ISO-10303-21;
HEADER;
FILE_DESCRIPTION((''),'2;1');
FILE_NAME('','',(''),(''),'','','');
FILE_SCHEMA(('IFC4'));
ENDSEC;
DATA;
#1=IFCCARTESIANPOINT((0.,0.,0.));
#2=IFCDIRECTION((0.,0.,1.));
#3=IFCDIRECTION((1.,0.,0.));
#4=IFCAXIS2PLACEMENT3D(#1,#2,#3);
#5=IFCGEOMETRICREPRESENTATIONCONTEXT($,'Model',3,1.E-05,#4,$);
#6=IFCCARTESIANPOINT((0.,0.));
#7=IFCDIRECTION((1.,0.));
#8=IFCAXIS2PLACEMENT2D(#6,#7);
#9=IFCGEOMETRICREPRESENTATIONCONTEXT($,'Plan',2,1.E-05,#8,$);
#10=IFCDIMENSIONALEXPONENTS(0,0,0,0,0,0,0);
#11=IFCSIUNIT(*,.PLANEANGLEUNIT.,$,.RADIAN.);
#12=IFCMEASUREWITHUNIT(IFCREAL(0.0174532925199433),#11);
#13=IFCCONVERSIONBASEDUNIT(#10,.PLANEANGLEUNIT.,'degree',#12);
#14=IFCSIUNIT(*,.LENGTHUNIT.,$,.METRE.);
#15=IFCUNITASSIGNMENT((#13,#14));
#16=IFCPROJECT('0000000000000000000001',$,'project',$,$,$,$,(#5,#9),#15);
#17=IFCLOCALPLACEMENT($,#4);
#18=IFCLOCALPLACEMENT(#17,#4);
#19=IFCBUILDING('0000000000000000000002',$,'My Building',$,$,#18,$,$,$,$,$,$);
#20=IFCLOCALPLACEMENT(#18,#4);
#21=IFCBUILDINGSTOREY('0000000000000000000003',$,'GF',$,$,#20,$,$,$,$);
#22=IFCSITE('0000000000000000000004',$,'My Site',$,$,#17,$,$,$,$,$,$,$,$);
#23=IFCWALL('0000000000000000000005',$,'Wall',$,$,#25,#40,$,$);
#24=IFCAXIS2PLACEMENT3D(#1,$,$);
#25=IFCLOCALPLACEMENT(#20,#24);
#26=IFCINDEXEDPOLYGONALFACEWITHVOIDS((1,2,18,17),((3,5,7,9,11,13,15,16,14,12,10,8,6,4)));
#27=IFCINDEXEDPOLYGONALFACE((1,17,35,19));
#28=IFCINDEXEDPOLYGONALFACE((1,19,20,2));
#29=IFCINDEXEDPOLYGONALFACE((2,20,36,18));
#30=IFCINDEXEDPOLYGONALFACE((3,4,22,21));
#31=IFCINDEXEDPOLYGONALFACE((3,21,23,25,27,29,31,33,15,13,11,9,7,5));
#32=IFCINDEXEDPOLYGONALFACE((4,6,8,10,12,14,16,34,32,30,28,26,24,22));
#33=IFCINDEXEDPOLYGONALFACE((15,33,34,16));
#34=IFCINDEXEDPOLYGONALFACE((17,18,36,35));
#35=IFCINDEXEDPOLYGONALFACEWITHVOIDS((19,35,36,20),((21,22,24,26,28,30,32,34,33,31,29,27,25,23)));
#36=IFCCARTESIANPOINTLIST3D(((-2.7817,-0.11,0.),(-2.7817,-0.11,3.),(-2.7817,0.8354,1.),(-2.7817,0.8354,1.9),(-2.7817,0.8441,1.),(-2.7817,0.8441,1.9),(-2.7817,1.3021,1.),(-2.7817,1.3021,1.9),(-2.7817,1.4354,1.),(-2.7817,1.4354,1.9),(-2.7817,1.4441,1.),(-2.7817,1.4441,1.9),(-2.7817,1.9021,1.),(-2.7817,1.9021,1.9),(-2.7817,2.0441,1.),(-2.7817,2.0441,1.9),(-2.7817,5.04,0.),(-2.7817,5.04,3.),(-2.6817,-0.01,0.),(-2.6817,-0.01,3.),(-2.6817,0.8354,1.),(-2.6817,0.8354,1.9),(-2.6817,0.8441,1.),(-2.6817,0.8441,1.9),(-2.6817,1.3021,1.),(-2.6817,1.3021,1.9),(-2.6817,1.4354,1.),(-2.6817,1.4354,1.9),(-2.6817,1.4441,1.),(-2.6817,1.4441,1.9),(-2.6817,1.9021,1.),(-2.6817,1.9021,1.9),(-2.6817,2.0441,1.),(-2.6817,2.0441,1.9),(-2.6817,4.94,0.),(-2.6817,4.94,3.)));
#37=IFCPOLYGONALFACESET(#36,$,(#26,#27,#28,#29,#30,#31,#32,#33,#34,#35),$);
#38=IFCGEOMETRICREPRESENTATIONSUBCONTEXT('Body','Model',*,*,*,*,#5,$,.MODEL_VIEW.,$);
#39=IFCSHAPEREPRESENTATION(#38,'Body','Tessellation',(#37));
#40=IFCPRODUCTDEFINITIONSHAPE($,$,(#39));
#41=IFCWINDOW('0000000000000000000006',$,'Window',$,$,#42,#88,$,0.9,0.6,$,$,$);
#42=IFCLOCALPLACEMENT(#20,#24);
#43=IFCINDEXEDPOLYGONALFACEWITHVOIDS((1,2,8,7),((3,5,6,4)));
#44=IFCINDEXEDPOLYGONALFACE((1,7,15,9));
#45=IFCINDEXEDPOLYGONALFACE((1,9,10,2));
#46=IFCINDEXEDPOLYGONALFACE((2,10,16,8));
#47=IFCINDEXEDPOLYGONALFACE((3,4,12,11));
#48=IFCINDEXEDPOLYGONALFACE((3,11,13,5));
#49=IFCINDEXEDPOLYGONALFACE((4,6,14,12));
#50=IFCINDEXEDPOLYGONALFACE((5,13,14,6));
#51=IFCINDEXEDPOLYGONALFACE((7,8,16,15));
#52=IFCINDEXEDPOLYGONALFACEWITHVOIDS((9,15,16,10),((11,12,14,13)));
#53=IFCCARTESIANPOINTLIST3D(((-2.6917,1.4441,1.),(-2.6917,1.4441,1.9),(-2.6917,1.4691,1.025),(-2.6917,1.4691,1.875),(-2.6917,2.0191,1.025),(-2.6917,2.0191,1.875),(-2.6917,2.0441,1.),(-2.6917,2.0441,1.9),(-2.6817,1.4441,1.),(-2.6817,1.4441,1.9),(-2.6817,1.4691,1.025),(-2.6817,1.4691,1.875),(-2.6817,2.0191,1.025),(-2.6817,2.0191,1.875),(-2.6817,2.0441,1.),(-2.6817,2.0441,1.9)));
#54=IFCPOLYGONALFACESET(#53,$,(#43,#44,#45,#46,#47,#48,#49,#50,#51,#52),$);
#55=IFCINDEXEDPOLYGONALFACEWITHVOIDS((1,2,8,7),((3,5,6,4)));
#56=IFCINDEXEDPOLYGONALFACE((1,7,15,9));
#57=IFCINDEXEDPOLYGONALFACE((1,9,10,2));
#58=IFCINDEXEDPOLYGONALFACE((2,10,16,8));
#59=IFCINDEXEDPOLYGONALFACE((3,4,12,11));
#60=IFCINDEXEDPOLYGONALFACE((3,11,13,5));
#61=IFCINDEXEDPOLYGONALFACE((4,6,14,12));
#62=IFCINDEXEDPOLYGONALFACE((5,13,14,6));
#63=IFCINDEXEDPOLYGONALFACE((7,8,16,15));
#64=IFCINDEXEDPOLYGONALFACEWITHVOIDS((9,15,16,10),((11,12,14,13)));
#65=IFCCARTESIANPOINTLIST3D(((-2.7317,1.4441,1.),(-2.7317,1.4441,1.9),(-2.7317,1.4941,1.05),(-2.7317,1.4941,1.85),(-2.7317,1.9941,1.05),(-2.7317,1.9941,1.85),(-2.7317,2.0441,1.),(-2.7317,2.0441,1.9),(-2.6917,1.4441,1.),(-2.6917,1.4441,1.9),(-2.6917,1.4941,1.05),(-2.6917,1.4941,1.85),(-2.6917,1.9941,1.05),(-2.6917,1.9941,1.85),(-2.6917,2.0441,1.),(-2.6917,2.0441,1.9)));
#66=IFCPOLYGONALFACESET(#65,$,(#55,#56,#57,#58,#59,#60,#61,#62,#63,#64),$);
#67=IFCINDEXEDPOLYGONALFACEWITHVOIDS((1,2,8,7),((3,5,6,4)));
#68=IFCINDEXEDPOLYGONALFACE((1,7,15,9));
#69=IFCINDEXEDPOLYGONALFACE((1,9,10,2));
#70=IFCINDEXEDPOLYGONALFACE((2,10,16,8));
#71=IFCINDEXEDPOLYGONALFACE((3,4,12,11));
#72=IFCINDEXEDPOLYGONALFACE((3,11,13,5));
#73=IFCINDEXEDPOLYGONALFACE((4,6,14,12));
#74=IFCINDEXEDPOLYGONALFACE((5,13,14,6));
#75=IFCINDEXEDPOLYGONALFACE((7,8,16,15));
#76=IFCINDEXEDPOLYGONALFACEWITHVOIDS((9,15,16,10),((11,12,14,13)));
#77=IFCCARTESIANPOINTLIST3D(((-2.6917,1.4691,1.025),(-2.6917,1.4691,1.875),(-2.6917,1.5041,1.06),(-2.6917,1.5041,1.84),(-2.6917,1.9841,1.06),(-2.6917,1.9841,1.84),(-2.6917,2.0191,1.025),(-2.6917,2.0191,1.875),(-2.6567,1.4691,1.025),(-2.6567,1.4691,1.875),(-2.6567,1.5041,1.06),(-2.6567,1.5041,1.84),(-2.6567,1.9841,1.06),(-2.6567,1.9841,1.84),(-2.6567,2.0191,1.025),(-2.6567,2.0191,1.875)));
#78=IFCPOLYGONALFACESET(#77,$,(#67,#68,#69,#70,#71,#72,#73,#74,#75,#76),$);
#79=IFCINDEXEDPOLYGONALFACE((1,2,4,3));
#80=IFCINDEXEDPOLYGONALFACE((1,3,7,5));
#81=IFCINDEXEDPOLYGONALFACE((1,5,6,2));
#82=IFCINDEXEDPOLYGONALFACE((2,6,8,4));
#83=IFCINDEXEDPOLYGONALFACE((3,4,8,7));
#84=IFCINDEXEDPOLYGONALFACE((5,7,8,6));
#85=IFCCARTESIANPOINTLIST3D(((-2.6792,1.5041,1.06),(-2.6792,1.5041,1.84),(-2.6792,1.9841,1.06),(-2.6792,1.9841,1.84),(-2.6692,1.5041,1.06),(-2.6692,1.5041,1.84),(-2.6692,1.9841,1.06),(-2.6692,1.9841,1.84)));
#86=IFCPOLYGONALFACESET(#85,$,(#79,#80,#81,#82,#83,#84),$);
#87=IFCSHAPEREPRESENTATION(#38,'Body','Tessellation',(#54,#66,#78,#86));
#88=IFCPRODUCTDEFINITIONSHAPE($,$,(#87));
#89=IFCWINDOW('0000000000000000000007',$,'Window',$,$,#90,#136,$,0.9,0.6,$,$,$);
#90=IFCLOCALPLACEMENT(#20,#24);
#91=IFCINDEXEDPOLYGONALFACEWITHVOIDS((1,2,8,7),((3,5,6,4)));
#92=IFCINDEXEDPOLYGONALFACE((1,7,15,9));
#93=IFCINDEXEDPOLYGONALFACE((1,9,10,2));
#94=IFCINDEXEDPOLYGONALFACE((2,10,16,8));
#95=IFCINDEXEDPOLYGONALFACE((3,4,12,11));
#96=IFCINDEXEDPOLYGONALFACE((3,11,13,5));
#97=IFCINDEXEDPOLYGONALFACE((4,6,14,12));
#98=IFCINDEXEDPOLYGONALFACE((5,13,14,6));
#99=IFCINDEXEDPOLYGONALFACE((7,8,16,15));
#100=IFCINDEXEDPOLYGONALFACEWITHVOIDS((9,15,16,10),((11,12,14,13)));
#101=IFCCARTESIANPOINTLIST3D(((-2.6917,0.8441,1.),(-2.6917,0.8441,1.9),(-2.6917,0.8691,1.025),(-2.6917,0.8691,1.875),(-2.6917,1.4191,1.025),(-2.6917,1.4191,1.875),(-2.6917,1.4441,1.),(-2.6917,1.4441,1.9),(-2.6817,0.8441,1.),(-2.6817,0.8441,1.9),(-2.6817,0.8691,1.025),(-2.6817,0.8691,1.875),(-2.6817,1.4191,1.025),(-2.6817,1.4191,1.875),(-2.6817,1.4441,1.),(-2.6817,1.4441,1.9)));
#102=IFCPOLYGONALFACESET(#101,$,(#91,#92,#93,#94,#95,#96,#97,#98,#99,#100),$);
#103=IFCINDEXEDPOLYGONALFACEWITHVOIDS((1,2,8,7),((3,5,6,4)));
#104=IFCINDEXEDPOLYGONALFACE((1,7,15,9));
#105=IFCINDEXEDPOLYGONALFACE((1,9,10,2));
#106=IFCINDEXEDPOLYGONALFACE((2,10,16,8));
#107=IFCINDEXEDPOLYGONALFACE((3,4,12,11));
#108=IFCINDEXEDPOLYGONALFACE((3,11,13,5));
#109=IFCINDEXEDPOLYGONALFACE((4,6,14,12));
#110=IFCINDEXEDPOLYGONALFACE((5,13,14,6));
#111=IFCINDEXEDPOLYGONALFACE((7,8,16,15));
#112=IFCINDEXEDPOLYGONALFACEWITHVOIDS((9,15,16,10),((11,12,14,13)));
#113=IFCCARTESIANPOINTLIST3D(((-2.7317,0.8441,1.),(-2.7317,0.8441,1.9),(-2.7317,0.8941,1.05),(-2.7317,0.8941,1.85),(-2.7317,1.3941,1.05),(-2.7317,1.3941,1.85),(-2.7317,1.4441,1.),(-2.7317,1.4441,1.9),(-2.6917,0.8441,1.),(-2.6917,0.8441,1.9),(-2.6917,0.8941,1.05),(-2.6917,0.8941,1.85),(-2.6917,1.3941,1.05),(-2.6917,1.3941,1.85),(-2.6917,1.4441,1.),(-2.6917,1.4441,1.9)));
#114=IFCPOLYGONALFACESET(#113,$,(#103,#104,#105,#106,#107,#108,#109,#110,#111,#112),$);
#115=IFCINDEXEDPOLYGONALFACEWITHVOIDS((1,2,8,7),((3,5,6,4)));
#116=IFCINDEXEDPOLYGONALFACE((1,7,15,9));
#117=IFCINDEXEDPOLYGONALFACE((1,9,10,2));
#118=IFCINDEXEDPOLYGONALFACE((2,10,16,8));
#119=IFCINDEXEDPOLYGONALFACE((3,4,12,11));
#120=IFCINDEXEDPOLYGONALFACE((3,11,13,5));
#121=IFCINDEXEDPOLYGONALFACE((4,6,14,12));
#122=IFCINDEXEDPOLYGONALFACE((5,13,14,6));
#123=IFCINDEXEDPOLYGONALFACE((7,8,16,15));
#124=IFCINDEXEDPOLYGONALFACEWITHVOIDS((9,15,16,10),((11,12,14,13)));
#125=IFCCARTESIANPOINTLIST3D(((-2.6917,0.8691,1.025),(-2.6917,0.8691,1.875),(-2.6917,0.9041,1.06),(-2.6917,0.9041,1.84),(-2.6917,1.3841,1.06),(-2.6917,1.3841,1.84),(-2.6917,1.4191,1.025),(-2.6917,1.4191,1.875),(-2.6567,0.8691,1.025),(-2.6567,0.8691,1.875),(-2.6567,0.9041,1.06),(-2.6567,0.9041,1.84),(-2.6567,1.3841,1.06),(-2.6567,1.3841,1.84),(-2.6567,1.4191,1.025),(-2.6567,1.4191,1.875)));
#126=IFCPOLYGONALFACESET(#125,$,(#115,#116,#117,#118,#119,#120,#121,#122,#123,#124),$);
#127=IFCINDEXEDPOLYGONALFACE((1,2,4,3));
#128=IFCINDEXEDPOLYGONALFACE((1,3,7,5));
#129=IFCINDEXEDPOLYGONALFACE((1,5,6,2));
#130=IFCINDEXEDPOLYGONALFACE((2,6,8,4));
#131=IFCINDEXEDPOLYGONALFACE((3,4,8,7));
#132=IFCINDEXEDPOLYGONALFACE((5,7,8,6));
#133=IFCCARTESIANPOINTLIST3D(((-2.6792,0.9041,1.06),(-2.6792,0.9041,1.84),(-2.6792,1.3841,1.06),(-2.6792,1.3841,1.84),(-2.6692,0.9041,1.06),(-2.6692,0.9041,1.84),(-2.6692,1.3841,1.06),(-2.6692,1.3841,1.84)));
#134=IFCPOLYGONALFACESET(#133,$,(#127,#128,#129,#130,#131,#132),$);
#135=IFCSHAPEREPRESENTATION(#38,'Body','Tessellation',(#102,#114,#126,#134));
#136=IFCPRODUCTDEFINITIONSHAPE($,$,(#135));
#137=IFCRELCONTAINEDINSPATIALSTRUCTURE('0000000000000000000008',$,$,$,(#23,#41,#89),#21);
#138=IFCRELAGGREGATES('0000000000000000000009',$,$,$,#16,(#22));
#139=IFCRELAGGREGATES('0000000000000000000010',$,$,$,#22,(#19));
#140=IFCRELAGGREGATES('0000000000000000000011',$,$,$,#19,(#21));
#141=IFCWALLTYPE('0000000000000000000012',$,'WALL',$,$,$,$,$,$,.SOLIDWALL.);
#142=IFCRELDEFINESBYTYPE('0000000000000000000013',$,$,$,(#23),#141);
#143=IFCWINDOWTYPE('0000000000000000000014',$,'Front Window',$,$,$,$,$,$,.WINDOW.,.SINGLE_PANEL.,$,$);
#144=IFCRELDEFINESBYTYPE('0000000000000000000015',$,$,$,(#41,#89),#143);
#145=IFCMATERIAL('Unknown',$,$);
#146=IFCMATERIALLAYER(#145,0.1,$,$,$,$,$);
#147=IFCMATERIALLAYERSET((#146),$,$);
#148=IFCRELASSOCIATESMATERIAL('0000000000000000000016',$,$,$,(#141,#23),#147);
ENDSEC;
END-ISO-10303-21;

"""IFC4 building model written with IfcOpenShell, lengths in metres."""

from ifc_helpers import new_model, entity, si_unit, converted_unit, frame, origin_with_axes, origin_2d_with_axis, place, context, subcontext, project, spatial, line, indexed_curve, outline, extrude, shape, source, transform, mapped, material, layer, layer_set, layer_usage, type_object, type_shapes, element, fill, save


model = new_model("IFC4")

# Units and contexts
model_context = context("Model", 3, precision=1e-05, world=origin_with_axes())
plan_context = context("Plan", 2, precision=1e-05, world=origin_2d_with_axis())
body_context_1 = subcontext(model_context, "Body", "Model", "MODEL_VIEW")
body_context_2 = subcontext(plan_context, "Body", "Plan", "PLAN_VIEW")
ifc_project = project(units=[converted_unit("PLANEANGLEUNIT", "degree", entity("IfcReal", 0.0174532925199433), si_unit("PLANEANGLEUNIT", "RADIAN"), dimensions=[0, 0, 0, 0, 0, 0, 0]), si_unit("LENGTHUNIT", "METRE")], contexts=[model_context, plan_context])

# Site, building, storey
site_placement = place(None, origin_with_axes())
site = spatial("IfcSite", under=ifc_project, at=site_placement, Name="My Site")
building_placement = place(site_placement, origin_with_axes())
building = spatial("IfcBuilding", under=site, at=building_placement, Name="My Building")
storey_placement = place(building_placement, origin_with_axes())
storey = spatial("IfcBuildingStorey", under=building, at=storey_placement, Name="GF")

# Shared definitions
ifc_material = material(Name="Unknown")

# Shared definitions
ifc_layer_1 = layer(ifc_material, 0.1)
ifc_layer_set_1 = layer_set([ifc_layer_1])
wall_type = type_object("IfcWallType", Name="WALL", PredefinedType="SOLIDWALL", material=ifc_layer_set_1)
shared_shape_1 = source(origin_with_axes(), body_context_1, "Body", "SweptSolid", [
    extrude(outline(indexed_curve([(0.0, 0.0), (0.6, 0.0), (0.6, 0.9), (0.0, 0.9)], segments=[line(1, 2, 3, 4, 1)])), frame((0.0, -0.6, 0.0), z_axis=(0.0, -1.0, 0.0), x_axis=(1.0, 0.0, 0.0)), (0.0, 0.0, -1.0), 1.2),
])
window_type = type_object("IfcWindowType", Name="Front Window", PartitioningType="SINGLE_PANEL", PredefinedType="WINDOW")
shared_shape_2 = source(origin_with_axes(), body_context_1, "Body", "SweptSolid", [
    extrude(outline(indexed_curve([(0.0, 0.0), (0.6, 0.0), (0.6, 0.9), (0.0, 0.9)], segments=[line(1, 2, 3, 4, 1)]), holes=[indexed_curve([(0.025, 0.025), (0.575, 0.025), (0.575, 0.875), (0.025, 0.875)], segments=[line(1, 2, 3, 4, 1)])]), frame((0.0, 0.09, 0.0), z_axis=(0.0, -1.0, 0.0), x_axis=(1.0, 0.0, 0.0)), (0.0, 0.0, -1.0), 0.01),
    extrude(outline(indexed_curve([(0.0, 0.0), (0.6, 0.0), (0.6, 0.9), (0.0, 0.9)], segments=[line(1, 2, 3, 4, 1)]), holes=[indexed_curve([(0.05, 0.05), (0.55, 0.05), (0.55, 0.85), (0.05, 0.85)], segments=[line(1, 2, 3, 4, 1)])]), frame((0.0, 0.05, 0.0), z_axis=(0.0, -1.0, 0.0), x_axis=(1.0, 0.0, 0.0)), (0.0, 0.0, -1.0), 0.04),
    extrude(outline(indexed_curve([(0.0, 0.0), (0.55, 0.0), (0.55, 0.85), (0.0, 0.85)], segments=[line(1, 2, 3, 4, 1)]), holes=[indexed_curve([(0.035, 0.035), (0.515, 0.035), (0.515, 0.815), (0.035, 0.815)], segments=[line(1, 2, 3, 4, 1)])]), frame((0.025, 0.09, 0.025), z_axis=(0.0, -1.0, 0.0), x_axis=(1.0, 0.0, 0.0)), (0.0, 0.0, -1.0), 0.035),
    extrude(outline(indexed_curve([(0.035, 0.035), (0.515, 0.035), (0.515, 0.815), (0.035, 0.815)], segments=[line(1, 2, 3, 4, 1)])), frame((0.025, 0.1025, 0.025), z_axis=(0.0, -1.0, 0.0), x_axis=(1.0, 0.0, 0.0)), (0.0, 0.0, -1.0), 0.01),
])
shared_shape_3 = source(origin_with_axes(), body_context_2, "Body", "Curve2D", [
    entity("IfcIndexedPolyCurve", entity("IfcCartesianPointList2D", [[0.05, 0.05], [0.55, 0.05]])),
    entity("IfcIndexedPolyCurve", entity("IfcCartesianPointList2D", [[0.0, 0.1], [0.025, 0.1], [0.025, 0.09], [0.05, 0.09], [0.05, 0.05], [0.0, 0.05]]), [entity("IfcLineIndex", [1, 2, 3, 4, 5, 6, 1])]),
    entity("IfcIndexedPolyCurve", entity("IfcCartesianPointList2D", [[0.6, 0.1], [0.575, 0.1], [0.575, 0.09], [0.55, 0.09], [0.55, 0.05], [0.6, 0.05]]), [entity("IfcLineIndex", [1, 2, 3, 4, 5, 6, 1])]),
    entity("IfcIndexedPolyCurve", entity("IfcCartesianPointList2D", [[0.025, 0.09], [0.06, 0.09], [0.06, 0.125], [0.025, 0.125]]), [entity("IfcLineIndex", [1, 2, 3, 4, 1])]),
    entity("IfcIndexedPolyCurve", entity("IfcCartesianPointList2D", [[0.575, 0.09], [0.54, 0.09], [0.54, 0.125], [0.575, 0.125]]), [entity("IfcLineIndex", [1, 2, 3, 4, 1])]),
    entity("IfcIndexedPolyCurve", entity("IfcCartesianPointList2D", [[0.06, 0.09], [0.54, 0.09]])),
    entity("IfcIndexedPolyCurve", entity("IfcCartesianPointList2D", [[0.06, 0.125], [0.54, 0.125]])),
    entity("IfcIndexedPolyCurve", entity("IfcCartesianPointList2D", [[0.06, 0.1075], [0.54, 0.1075]])),
])
type_shapes(window_type, [shared_shape_2, shared_shape_3])

# Wall, openings, windows
ifc_layer_usage_1 = layer_usage(ifc_layer_set_1, "AXIS2", "POSITIVE", 0.0)
wall_1_placement = place(storey_placement, frame((-2.7817, 5.04, 0.0), z_axis=(0.0, 0.0, 1.0), x_axis=(0.0, -1.0, 0.0)))
wall_1 = element("IfcWall", 1, at=wall_1_placement, inside=storey, type_object=wall_type, material=ifc_layer_usage_1, Name="Wall", context=body_context_1, shape_type="SweptSolid", body=[
    extrude(outline(indexed_curve([(0.0, 0.0), (0.1, 0.1), (5.05, 0.1), (5.15, 0.0)], segments=[line(1, 2, 3, 4, 1)])), origin_with_axes(), (0.0, 0.0, 1.0), 3.0),
])
opening_1_placement = place(wall_1_placement, frame((2.9959, 0.0, 1.0), z_axis=(0.0, 0.0, 1.0), x_axis=(1.0, 0.0, 0.0)))
opening_1 = element("IfcOpeningElement", 2, at=opening_1_placement, cuts=wall_1, PredefinedType="OPENING", context=body_context_1, shape_type="MappedRepresentation", body=[
    mapped(shared_shape_1, transform((0.0, 0.0, 0.0), x_axis=(1.0, 0.0, 0.0), y_axis=(0.0, 1.0, 0.0), z_axis=(0.0, 0.0, 1.0), scale=1.0)),
])
opening_2_placement = place(wall_1_placement, frame((3.5959, 0.0, 1.0), z_axis=(0.0, 0.0, 1.0), x_axis=(1.0, 0.0, 0.0)))
opening_2 = element("IfcOpeningElement", 3, at=opening_2_placement, cuts=wall_1, PredefinedType="OPENING", context=body_context_1, shape_type="MappedRepresentation", body=[
    mapped(shared_shape_1, transform((0.0, 0.0, 0.0), x_axis=(1.0, 0.0, 0.0), y_axis=(0.0, 1.0, 0.0), z_axis=(0.0, 0.0, 1.0), scale=1.0)),
])
shared_shape_4 = source(origin_with_axes(), body_context_1, "Body", "SweptSolid", [
    extrude(outline(indexed_curve([(0.0, 0.0), (0.6, 0.0), (0.6, 0.9), (0.0, 0.9)], segments=[line(1, 2, 3, 4, 1)])), frame((0.0, -0.6, 0.0), z_axis=(0.0, -1.0, 0.0), x_axis=(1.0, 0.0, 0.0)), (0.0, 0.0, -1.0), 1.2),
])
opening_3_placement = place(wall_1_placement, frame((3.1379, 0.0, 1.0), z_axis=(0.0, 0.0, 1.0), x_axis=(1.0, 0.0, 0.0)))
element("IfcOpeningElement", 4, at=opening_3_placement, cuts=wall_1, PredefinedType="OPENING", context=body_context_1, shape_type="MappedRepresentation", body=[
    mapped(shared_shape_4, transform((0.0, 0.0, 0.0), x_axis=(1.0, 0.0, 0.0), y_axis=(0.0, 1.0, 0.0), z_axis=(0.0, 0.0, 1.0), scale=1.0)),
])
opening_4_placement = place(wall_1_placement, frame((3.6045, 0.0, 1.0), z_axis=(0.0, 0.0, 1.0), x_axis=(1.0, 0.0, 0.0)))
element("IfcOpeningElement", 5, at=opening_4_placement, cuts=wall_1, PredefinedType="OPENING", context=body_context_1, shape_type="MappedRepresentation", body=[
    mapped(shared_shape_4, transform((0.0, 0.0, 0.0), x_axis=(1.0, 0.0, 0.0), y_axis=(0.0, 1.0, 0.0), z_axis=(0.0, 0.0, 1.0), scale=1.0)),
])
opening_5_placement = place(wall_1_placement, frame((2.9959, 0.0, 1.0), z_axis=(0.0, 0.0, 1.0), x_axis=(1.0, 0.0, 0.0)))
element("IfcOpeningElement", 6, at=opening_5_placement, cuts=wall_1, PredefinedType="OPENING", context=body_context_1, shape_type="MappedRepresentation", body=[
    mapped(shared_shape_4, transform((0.0, 0.0, 0.0), x_axis=(1.0, 0.0, 0.0), y_axis=(0.0, 1.0, 0.0), z_axis=(0.0, 0.0, 1.0), scale=1.0)),
])
window_1_placement = place(opening_1_placement, origin_with_axes())
window_1 = element("IfcWindow", 7, at=window_1_placement, inside=storey, type_object=window_type, Name="Window", OverallHeight=0.9, OverallWidth=0.6, shapes=[
    shape(body_context_1, "Body", "MappedRepresentation", [mapped(shared_shape_2, transform((0.0, 0.0, 0.0), x_axis=(1.0, 0.0, 0.0), y_axis=(0.0, 1.0, 0.0), z_axis=(0.0, 0.0, 1.0), scale=1.0))]),
    shape(body_context_2, "Body", "MappedRepresentation", [mapped(shared_shape_3, transform((0.0, 0.0, 0.0), x_axis=(1.0, 0.0, 0.0), y_axis=(0.0, 1.0, 0.0), z_axis=(0.0, 0.0, 1.0), scale=1.0))]),
])
fill(opening_1, window_1)
window_2_placement = place(opening_2_placement, frame((0.0, 0.0, 0.0), z_axis=(0.0, 0.0, 1.0), x_axis=(1.0, 0.0, 0.0)))
window_2 = element("IfcWindow", 8, at=window_2_placement, inside=storey, type_object=window_type, Name="Window", OverallHeight=0.9, OverallWidth=0.6, shapes=[
    shape(body_context_1, "Body", "MappedRepresentation", [mapped(shared_shape_2, transform((0.0, 0.0, 0.0), x_axis=(1.0, 0.0, 0.0), y_axis=(0.0, 1.0, 0.0), z_axis=(0.0, 0.0, 1.0), scale=1.0))]),
    shape(body_context_2, "Body", "MappedRepresentation", [mapped(shared_shape_3, transform((0.0, 0.0, 0.0), x_axis=(1.0, 0.0, 0.0), y_axis=(0.0, 1.0, 0.0), z_axis=(0.0, 0.0, 1.0), scale=1.0))]),
])
fill(opening_2, window_2)

save(model, "model.ifc")
